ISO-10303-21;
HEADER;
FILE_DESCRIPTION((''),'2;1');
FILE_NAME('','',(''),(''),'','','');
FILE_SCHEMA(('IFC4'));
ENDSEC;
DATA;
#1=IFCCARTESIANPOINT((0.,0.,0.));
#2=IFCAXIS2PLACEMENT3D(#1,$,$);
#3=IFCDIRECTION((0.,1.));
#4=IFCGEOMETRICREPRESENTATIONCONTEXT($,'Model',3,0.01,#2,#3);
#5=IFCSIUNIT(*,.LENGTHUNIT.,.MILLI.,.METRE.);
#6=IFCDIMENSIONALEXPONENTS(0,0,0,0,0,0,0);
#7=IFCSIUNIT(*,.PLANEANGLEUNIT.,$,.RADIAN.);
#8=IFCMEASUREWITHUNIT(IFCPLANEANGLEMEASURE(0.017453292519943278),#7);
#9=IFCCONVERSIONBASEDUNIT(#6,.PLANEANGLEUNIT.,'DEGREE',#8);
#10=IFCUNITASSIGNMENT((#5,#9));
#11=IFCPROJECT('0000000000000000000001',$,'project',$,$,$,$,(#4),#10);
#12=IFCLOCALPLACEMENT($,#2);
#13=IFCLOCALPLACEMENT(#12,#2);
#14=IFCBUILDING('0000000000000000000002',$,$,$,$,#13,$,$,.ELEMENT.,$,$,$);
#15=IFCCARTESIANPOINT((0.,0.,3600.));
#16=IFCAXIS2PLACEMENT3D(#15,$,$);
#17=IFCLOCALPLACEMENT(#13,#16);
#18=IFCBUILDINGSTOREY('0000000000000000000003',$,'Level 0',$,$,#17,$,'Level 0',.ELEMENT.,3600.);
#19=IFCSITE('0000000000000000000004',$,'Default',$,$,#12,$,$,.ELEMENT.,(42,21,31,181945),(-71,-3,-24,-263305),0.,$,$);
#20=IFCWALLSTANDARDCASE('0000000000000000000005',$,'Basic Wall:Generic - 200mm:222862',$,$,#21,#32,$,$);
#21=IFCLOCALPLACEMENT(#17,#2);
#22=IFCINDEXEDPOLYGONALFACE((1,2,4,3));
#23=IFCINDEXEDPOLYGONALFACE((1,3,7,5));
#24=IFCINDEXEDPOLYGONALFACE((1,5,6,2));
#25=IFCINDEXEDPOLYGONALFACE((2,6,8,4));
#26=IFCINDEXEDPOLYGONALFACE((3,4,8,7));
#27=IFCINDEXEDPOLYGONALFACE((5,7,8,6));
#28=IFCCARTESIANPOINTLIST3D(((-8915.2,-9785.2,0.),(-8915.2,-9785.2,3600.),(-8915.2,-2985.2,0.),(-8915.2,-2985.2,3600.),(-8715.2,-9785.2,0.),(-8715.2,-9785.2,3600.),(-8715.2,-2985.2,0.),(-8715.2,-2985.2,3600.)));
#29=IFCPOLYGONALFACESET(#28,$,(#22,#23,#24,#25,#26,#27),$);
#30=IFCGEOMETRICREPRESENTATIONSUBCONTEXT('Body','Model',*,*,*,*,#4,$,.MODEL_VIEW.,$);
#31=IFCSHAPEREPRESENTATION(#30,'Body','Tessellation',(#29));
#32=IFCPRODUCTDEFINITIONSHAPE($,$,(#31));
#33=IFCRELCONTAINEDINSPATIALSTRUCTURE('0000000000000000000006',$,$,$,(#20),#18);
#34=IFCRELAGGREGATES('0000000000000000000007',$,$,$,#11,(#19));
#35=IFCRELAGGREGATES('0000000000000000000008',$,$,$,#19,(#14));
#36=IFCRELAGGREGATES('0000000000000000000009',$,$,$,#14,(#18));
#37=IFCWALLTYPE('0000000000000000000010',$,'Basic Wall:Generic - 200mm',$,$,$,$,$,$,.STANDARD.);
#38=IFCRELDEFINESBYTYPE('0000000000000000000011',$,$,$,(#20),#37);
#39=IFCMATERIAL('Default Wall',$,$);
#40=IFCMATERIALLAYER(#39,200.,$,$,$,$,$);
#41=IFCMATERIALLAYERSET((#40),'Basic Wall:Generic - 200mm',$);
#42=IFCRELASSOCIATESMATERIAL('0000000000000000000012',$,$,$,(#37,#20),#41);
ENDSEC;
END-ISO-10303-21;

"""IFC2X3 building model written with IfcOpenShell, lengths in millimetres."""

from ifc_helpers import new_model, entity, si_unit, converted_unit, direction, frame, frame_2d, origin, place, context, subcontext, project, spatial, rectangle, extrude, material, layer, layer_set, layer_usage, type_object, element, save


model = new_model("IFC2X3")

# Units and contexts
model_context = context("Model", 3, precision=0.01, world=origin(), true_north=direction((0.0, 1.0)))
body_context = subcontext(model_context, "Body", "Model", "MODEL_VIEW")
ifc_project = project(units=[si_unit("LENGTHUNIT", "METRE", prefix="MILLI"), converted_unit("PLANEANGLEUNIT", "DEGREE", entity("IfcPlaneAngleMeasure", 0.017453292519943278), si_unit("PLANEANGLEUNIT", "RADIAN"), dimensions=[0, 0, 0, 0, 0, 0, 0])], contexts=[model_context])

# Site, building, storey
site_placement = place(None, origin())
site = spatial("IfcSite", under=ifc_project, at=site_placement, Name="Default", CompositionType="ELEMENT", RefLatitude=(42, 21, 31, 181945), RefLongitude=(-71, -3, -24, -263305), RefElevation=0.0)
building_placement = place(site_placement, origin())
building = spatial("IfcBuilding", under=site, at=building_placement, CompositionType="ELEMENT")
storey_placement = place(building_placement, frame((0.0, 0.0, 3600.0)))
storey = spatial("IfcBuildingStorey", under=building, at=storey_placement, Name="Level 0", LongName="Level 0", CompositionType="ELEMENT", Elevation=3600.0)

# Wall
ifc_material_1 = material(Name="Default Wall")
ifc_layer = layer(ifc_material_1, 200.0)
ifc_layer_set = layer_set([ifc_layer], Name="Basic Wall:Generic - 200mm")
wall_type = type_object("IfcWallType", Name="Basic Wall:Generic - 200mm", PredefinedType="STANDARD", material=ifc_layer_set)
ifc_layer_usage_1 = layer_usage(ifc_layer_set, "AXIS2", "NEGATIVE", 100.0)
wall_1_placement = place(storey_placement, frame((-8815.2, -9785.2, 0.0), z_axis=(0.0, 0.0, 1.0), x_axis=(0.0, 1.0, 0.0)))
element("IfcWallStandardCase", 1, at=wall_1_placement, inside=storey, type_object=wall_type, material=ifc_layer_usage_1, Name="Basic Wall:Generic - 200mm:222862", context=body_context, shape_type="SweptSolid", body=[
    extrude(rectangle(XDim=6800.0, YDim=200.0, at=frame_2d((3400.0, 0.0), x_axis=(-1.0, 0.0))), origin(), (0.0, 0.0, 1.0), 3600.0),
])

save(model, "model.ifc")
